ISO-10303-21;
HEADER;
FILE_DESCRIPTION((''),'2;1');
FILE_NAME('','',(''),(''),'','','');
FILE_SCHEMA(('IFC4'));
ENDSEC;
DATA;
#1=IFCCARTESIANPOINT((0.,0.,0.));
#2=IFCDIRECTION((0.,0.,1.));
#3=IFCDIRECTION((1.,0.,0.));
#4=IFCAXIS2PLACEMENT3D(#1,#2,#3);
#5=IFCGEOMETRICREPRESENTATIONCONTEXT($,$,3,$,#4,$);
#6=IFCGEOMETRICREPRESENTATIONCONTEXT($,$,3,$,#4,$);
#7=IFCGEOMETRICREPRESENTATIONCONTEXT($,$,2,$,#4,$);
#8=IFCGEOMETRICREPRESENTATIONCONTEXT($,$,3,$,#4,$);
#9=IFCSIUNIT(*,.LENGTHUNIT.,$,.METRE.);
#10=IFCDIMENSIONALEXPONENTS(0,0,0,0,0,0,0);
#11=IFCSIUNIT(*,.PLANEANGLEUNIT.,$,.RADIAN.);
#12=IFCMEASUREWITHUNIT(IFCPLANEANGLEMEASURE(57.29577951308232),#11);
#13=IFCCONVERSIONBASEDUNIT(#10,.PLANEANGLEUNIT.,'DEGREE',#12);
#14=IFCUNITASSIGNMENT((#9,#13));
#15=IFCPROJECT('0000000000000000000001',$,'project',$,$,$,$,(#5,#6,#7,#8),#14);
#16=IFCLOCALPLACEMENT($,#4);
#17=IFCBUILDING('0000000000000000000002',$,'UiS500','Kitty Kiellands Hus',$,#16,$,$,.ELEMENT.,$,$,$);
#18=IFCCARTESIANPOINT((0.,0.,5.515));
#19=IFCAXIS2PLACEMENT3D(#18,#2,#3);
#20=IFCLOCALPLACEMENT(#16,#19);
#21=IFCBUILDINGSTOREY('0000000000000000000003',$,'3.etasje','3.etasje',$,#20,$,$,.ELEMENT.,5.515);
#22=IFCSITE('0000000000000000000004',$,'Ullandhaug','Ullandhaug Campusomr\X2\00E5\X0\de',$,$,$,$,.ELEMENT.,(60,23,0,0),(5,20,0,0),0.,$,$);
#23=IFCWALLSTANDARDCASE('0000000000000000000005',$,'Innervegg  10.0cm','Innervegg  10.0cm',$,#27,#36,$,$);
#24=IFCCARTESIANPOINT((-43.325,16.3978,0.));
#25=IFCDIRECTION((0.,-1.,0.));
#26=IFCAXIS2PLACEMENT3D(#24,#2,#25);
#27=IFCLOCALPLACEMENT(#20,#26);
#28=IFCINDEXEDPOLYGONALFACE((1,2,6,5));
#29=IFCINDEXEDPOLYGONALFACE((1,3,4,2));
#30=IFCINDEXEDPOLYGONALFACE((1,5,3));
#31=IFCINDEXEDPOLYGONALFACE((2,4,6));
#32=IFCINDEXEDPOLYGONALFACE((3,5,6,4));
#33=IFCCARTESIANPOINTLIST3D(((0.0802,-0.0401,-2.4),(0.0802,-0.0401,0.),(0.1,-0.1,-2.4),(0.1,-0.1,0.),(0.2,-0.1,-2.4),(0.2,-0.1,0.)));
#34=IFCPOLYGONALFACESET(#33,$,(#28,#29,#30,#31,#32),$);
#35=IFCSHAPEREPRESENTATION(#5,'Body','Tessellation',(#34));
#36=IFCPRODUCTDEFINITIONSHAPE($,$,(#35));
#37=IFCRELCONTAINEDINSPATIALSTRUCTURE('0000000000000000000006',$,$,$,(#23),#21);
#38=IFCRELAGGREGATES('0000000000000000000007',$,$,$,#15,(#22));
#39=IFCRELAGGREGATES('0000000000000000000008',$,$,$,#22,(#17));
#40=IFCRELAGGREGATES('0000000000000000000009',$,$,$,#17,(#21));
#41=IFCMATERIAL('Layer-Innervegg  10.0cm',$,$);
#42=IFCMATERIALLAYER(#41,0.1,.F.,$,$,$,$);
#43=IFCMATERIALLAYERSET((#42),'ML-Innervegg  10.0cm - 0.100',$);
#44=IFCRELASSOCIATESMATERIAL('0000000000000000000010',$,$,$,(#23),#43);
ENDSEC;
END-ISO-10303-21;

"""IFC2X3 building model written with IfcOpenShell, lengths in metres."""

from ifc_helpers import new_model, entity, si_unit, converted_unit, frame, origin_with_axes, place, context, project, spatial, polyline, outline, extrude, material, layer, layer_set, layer_usage, element, save


model = new_model("IFC2X3")

# Units and contexts
context_of_model_1 = context(None, 3, world=origin_with_axes())
context_of_model_2 = context(None, 3, world=origin_with_axes())
context_of_model_3 = context(None, 2, world=origin_with_axes())
context_of_model_4 = context(None, 3, world=origin_with_axes())
ifc_project = project(units=[si_unit("LENGTHUNIT", "METRE"), converted_unit("PLANEANGLEUNIT", "DEGREE", entity("IfcPlaneAngleMeasure", 57.29577951308232), si_unit("PLANEANGLEUNIT", "RADIAN"), dimensions=[0, 0, 0, 0, 0, 0, 0])], contexts=[context_of_model_1, context_of_model_2, context_of_model_3, context_of_model_4])

# Site, building, storey
site = spatial("IfcSite", under=ifc_project, Name="Ullandhaug", Description="Ullandhaug Campusområde", CompositionType="ELEMENT", RefLatitude=(60, 23, 0, 0), RefLongitude=(5, 20, 0, 0), RefElevation=0.0)
building_placement = place(None, origin_with_axes())
building = spatial("IfcBuilding", under=site, at=building_placement, Name="UiS500", Description="Kitty Kiellands Hus", CompositionType="ELEMENT")
storey_placement = place(building_placement, frame((0.0, 0.0, 5.515), z_axis=(0.0, 0.0, 1.0), x_axis=(1.0, 0.0, 0.0)))
storey = spatial("IfcBuildingStorey", under=building, at=storey_placement, Name="3.etasje", Description="3.etasje", CompositionType="ELEMENT", Elevation=5.515)

# Shared definitions
ifc_material_1 = material(Name="Layer-Innervegg  10.0cm")
ifc_layer_1 = layer(ifc_material_1, 0.1, ventilated=False)
ifc_layer_set_1 = layer_set([ifc_layer_1], Name="ML-Innervegg  10.0cm - 0.100")
ifc_layer_usage_1 = layer_usage(ifc_layer_set_1, "AXIS2", "POSITIVE", 0.0)

# Wall
wall_1_placement = place(storey_placement, frame((-43.325, 16.3978, 0.0), z_axis=(0.0, 0.0, 1.0), x_axis=(0.0, -1.0, 0.0)))
element("IfcWallStandardCase", 1, at=wall_1_placement, inside=storey, material=ifc_layer_usage_1, Name="Innervegg  10.0cm", Description="Innervegg  10.0cm", context=context_of_model_1, shape_type="SweptSolid", body=[
    extrude(outline(polyline([(0.0, 0.0), (0.067, 0.0), (0.1, 0.1), (0.2, 0.1), (0.0, 0.0)])), frame((0.0, 0.0, 0.0), z_axis=(0.0, 0.0, -1.0), x_axis=(1.0, 0.0, 0.0)), (0.0, 0.0, 1.0), 2.4),
])

save(model, "model.ifc")
